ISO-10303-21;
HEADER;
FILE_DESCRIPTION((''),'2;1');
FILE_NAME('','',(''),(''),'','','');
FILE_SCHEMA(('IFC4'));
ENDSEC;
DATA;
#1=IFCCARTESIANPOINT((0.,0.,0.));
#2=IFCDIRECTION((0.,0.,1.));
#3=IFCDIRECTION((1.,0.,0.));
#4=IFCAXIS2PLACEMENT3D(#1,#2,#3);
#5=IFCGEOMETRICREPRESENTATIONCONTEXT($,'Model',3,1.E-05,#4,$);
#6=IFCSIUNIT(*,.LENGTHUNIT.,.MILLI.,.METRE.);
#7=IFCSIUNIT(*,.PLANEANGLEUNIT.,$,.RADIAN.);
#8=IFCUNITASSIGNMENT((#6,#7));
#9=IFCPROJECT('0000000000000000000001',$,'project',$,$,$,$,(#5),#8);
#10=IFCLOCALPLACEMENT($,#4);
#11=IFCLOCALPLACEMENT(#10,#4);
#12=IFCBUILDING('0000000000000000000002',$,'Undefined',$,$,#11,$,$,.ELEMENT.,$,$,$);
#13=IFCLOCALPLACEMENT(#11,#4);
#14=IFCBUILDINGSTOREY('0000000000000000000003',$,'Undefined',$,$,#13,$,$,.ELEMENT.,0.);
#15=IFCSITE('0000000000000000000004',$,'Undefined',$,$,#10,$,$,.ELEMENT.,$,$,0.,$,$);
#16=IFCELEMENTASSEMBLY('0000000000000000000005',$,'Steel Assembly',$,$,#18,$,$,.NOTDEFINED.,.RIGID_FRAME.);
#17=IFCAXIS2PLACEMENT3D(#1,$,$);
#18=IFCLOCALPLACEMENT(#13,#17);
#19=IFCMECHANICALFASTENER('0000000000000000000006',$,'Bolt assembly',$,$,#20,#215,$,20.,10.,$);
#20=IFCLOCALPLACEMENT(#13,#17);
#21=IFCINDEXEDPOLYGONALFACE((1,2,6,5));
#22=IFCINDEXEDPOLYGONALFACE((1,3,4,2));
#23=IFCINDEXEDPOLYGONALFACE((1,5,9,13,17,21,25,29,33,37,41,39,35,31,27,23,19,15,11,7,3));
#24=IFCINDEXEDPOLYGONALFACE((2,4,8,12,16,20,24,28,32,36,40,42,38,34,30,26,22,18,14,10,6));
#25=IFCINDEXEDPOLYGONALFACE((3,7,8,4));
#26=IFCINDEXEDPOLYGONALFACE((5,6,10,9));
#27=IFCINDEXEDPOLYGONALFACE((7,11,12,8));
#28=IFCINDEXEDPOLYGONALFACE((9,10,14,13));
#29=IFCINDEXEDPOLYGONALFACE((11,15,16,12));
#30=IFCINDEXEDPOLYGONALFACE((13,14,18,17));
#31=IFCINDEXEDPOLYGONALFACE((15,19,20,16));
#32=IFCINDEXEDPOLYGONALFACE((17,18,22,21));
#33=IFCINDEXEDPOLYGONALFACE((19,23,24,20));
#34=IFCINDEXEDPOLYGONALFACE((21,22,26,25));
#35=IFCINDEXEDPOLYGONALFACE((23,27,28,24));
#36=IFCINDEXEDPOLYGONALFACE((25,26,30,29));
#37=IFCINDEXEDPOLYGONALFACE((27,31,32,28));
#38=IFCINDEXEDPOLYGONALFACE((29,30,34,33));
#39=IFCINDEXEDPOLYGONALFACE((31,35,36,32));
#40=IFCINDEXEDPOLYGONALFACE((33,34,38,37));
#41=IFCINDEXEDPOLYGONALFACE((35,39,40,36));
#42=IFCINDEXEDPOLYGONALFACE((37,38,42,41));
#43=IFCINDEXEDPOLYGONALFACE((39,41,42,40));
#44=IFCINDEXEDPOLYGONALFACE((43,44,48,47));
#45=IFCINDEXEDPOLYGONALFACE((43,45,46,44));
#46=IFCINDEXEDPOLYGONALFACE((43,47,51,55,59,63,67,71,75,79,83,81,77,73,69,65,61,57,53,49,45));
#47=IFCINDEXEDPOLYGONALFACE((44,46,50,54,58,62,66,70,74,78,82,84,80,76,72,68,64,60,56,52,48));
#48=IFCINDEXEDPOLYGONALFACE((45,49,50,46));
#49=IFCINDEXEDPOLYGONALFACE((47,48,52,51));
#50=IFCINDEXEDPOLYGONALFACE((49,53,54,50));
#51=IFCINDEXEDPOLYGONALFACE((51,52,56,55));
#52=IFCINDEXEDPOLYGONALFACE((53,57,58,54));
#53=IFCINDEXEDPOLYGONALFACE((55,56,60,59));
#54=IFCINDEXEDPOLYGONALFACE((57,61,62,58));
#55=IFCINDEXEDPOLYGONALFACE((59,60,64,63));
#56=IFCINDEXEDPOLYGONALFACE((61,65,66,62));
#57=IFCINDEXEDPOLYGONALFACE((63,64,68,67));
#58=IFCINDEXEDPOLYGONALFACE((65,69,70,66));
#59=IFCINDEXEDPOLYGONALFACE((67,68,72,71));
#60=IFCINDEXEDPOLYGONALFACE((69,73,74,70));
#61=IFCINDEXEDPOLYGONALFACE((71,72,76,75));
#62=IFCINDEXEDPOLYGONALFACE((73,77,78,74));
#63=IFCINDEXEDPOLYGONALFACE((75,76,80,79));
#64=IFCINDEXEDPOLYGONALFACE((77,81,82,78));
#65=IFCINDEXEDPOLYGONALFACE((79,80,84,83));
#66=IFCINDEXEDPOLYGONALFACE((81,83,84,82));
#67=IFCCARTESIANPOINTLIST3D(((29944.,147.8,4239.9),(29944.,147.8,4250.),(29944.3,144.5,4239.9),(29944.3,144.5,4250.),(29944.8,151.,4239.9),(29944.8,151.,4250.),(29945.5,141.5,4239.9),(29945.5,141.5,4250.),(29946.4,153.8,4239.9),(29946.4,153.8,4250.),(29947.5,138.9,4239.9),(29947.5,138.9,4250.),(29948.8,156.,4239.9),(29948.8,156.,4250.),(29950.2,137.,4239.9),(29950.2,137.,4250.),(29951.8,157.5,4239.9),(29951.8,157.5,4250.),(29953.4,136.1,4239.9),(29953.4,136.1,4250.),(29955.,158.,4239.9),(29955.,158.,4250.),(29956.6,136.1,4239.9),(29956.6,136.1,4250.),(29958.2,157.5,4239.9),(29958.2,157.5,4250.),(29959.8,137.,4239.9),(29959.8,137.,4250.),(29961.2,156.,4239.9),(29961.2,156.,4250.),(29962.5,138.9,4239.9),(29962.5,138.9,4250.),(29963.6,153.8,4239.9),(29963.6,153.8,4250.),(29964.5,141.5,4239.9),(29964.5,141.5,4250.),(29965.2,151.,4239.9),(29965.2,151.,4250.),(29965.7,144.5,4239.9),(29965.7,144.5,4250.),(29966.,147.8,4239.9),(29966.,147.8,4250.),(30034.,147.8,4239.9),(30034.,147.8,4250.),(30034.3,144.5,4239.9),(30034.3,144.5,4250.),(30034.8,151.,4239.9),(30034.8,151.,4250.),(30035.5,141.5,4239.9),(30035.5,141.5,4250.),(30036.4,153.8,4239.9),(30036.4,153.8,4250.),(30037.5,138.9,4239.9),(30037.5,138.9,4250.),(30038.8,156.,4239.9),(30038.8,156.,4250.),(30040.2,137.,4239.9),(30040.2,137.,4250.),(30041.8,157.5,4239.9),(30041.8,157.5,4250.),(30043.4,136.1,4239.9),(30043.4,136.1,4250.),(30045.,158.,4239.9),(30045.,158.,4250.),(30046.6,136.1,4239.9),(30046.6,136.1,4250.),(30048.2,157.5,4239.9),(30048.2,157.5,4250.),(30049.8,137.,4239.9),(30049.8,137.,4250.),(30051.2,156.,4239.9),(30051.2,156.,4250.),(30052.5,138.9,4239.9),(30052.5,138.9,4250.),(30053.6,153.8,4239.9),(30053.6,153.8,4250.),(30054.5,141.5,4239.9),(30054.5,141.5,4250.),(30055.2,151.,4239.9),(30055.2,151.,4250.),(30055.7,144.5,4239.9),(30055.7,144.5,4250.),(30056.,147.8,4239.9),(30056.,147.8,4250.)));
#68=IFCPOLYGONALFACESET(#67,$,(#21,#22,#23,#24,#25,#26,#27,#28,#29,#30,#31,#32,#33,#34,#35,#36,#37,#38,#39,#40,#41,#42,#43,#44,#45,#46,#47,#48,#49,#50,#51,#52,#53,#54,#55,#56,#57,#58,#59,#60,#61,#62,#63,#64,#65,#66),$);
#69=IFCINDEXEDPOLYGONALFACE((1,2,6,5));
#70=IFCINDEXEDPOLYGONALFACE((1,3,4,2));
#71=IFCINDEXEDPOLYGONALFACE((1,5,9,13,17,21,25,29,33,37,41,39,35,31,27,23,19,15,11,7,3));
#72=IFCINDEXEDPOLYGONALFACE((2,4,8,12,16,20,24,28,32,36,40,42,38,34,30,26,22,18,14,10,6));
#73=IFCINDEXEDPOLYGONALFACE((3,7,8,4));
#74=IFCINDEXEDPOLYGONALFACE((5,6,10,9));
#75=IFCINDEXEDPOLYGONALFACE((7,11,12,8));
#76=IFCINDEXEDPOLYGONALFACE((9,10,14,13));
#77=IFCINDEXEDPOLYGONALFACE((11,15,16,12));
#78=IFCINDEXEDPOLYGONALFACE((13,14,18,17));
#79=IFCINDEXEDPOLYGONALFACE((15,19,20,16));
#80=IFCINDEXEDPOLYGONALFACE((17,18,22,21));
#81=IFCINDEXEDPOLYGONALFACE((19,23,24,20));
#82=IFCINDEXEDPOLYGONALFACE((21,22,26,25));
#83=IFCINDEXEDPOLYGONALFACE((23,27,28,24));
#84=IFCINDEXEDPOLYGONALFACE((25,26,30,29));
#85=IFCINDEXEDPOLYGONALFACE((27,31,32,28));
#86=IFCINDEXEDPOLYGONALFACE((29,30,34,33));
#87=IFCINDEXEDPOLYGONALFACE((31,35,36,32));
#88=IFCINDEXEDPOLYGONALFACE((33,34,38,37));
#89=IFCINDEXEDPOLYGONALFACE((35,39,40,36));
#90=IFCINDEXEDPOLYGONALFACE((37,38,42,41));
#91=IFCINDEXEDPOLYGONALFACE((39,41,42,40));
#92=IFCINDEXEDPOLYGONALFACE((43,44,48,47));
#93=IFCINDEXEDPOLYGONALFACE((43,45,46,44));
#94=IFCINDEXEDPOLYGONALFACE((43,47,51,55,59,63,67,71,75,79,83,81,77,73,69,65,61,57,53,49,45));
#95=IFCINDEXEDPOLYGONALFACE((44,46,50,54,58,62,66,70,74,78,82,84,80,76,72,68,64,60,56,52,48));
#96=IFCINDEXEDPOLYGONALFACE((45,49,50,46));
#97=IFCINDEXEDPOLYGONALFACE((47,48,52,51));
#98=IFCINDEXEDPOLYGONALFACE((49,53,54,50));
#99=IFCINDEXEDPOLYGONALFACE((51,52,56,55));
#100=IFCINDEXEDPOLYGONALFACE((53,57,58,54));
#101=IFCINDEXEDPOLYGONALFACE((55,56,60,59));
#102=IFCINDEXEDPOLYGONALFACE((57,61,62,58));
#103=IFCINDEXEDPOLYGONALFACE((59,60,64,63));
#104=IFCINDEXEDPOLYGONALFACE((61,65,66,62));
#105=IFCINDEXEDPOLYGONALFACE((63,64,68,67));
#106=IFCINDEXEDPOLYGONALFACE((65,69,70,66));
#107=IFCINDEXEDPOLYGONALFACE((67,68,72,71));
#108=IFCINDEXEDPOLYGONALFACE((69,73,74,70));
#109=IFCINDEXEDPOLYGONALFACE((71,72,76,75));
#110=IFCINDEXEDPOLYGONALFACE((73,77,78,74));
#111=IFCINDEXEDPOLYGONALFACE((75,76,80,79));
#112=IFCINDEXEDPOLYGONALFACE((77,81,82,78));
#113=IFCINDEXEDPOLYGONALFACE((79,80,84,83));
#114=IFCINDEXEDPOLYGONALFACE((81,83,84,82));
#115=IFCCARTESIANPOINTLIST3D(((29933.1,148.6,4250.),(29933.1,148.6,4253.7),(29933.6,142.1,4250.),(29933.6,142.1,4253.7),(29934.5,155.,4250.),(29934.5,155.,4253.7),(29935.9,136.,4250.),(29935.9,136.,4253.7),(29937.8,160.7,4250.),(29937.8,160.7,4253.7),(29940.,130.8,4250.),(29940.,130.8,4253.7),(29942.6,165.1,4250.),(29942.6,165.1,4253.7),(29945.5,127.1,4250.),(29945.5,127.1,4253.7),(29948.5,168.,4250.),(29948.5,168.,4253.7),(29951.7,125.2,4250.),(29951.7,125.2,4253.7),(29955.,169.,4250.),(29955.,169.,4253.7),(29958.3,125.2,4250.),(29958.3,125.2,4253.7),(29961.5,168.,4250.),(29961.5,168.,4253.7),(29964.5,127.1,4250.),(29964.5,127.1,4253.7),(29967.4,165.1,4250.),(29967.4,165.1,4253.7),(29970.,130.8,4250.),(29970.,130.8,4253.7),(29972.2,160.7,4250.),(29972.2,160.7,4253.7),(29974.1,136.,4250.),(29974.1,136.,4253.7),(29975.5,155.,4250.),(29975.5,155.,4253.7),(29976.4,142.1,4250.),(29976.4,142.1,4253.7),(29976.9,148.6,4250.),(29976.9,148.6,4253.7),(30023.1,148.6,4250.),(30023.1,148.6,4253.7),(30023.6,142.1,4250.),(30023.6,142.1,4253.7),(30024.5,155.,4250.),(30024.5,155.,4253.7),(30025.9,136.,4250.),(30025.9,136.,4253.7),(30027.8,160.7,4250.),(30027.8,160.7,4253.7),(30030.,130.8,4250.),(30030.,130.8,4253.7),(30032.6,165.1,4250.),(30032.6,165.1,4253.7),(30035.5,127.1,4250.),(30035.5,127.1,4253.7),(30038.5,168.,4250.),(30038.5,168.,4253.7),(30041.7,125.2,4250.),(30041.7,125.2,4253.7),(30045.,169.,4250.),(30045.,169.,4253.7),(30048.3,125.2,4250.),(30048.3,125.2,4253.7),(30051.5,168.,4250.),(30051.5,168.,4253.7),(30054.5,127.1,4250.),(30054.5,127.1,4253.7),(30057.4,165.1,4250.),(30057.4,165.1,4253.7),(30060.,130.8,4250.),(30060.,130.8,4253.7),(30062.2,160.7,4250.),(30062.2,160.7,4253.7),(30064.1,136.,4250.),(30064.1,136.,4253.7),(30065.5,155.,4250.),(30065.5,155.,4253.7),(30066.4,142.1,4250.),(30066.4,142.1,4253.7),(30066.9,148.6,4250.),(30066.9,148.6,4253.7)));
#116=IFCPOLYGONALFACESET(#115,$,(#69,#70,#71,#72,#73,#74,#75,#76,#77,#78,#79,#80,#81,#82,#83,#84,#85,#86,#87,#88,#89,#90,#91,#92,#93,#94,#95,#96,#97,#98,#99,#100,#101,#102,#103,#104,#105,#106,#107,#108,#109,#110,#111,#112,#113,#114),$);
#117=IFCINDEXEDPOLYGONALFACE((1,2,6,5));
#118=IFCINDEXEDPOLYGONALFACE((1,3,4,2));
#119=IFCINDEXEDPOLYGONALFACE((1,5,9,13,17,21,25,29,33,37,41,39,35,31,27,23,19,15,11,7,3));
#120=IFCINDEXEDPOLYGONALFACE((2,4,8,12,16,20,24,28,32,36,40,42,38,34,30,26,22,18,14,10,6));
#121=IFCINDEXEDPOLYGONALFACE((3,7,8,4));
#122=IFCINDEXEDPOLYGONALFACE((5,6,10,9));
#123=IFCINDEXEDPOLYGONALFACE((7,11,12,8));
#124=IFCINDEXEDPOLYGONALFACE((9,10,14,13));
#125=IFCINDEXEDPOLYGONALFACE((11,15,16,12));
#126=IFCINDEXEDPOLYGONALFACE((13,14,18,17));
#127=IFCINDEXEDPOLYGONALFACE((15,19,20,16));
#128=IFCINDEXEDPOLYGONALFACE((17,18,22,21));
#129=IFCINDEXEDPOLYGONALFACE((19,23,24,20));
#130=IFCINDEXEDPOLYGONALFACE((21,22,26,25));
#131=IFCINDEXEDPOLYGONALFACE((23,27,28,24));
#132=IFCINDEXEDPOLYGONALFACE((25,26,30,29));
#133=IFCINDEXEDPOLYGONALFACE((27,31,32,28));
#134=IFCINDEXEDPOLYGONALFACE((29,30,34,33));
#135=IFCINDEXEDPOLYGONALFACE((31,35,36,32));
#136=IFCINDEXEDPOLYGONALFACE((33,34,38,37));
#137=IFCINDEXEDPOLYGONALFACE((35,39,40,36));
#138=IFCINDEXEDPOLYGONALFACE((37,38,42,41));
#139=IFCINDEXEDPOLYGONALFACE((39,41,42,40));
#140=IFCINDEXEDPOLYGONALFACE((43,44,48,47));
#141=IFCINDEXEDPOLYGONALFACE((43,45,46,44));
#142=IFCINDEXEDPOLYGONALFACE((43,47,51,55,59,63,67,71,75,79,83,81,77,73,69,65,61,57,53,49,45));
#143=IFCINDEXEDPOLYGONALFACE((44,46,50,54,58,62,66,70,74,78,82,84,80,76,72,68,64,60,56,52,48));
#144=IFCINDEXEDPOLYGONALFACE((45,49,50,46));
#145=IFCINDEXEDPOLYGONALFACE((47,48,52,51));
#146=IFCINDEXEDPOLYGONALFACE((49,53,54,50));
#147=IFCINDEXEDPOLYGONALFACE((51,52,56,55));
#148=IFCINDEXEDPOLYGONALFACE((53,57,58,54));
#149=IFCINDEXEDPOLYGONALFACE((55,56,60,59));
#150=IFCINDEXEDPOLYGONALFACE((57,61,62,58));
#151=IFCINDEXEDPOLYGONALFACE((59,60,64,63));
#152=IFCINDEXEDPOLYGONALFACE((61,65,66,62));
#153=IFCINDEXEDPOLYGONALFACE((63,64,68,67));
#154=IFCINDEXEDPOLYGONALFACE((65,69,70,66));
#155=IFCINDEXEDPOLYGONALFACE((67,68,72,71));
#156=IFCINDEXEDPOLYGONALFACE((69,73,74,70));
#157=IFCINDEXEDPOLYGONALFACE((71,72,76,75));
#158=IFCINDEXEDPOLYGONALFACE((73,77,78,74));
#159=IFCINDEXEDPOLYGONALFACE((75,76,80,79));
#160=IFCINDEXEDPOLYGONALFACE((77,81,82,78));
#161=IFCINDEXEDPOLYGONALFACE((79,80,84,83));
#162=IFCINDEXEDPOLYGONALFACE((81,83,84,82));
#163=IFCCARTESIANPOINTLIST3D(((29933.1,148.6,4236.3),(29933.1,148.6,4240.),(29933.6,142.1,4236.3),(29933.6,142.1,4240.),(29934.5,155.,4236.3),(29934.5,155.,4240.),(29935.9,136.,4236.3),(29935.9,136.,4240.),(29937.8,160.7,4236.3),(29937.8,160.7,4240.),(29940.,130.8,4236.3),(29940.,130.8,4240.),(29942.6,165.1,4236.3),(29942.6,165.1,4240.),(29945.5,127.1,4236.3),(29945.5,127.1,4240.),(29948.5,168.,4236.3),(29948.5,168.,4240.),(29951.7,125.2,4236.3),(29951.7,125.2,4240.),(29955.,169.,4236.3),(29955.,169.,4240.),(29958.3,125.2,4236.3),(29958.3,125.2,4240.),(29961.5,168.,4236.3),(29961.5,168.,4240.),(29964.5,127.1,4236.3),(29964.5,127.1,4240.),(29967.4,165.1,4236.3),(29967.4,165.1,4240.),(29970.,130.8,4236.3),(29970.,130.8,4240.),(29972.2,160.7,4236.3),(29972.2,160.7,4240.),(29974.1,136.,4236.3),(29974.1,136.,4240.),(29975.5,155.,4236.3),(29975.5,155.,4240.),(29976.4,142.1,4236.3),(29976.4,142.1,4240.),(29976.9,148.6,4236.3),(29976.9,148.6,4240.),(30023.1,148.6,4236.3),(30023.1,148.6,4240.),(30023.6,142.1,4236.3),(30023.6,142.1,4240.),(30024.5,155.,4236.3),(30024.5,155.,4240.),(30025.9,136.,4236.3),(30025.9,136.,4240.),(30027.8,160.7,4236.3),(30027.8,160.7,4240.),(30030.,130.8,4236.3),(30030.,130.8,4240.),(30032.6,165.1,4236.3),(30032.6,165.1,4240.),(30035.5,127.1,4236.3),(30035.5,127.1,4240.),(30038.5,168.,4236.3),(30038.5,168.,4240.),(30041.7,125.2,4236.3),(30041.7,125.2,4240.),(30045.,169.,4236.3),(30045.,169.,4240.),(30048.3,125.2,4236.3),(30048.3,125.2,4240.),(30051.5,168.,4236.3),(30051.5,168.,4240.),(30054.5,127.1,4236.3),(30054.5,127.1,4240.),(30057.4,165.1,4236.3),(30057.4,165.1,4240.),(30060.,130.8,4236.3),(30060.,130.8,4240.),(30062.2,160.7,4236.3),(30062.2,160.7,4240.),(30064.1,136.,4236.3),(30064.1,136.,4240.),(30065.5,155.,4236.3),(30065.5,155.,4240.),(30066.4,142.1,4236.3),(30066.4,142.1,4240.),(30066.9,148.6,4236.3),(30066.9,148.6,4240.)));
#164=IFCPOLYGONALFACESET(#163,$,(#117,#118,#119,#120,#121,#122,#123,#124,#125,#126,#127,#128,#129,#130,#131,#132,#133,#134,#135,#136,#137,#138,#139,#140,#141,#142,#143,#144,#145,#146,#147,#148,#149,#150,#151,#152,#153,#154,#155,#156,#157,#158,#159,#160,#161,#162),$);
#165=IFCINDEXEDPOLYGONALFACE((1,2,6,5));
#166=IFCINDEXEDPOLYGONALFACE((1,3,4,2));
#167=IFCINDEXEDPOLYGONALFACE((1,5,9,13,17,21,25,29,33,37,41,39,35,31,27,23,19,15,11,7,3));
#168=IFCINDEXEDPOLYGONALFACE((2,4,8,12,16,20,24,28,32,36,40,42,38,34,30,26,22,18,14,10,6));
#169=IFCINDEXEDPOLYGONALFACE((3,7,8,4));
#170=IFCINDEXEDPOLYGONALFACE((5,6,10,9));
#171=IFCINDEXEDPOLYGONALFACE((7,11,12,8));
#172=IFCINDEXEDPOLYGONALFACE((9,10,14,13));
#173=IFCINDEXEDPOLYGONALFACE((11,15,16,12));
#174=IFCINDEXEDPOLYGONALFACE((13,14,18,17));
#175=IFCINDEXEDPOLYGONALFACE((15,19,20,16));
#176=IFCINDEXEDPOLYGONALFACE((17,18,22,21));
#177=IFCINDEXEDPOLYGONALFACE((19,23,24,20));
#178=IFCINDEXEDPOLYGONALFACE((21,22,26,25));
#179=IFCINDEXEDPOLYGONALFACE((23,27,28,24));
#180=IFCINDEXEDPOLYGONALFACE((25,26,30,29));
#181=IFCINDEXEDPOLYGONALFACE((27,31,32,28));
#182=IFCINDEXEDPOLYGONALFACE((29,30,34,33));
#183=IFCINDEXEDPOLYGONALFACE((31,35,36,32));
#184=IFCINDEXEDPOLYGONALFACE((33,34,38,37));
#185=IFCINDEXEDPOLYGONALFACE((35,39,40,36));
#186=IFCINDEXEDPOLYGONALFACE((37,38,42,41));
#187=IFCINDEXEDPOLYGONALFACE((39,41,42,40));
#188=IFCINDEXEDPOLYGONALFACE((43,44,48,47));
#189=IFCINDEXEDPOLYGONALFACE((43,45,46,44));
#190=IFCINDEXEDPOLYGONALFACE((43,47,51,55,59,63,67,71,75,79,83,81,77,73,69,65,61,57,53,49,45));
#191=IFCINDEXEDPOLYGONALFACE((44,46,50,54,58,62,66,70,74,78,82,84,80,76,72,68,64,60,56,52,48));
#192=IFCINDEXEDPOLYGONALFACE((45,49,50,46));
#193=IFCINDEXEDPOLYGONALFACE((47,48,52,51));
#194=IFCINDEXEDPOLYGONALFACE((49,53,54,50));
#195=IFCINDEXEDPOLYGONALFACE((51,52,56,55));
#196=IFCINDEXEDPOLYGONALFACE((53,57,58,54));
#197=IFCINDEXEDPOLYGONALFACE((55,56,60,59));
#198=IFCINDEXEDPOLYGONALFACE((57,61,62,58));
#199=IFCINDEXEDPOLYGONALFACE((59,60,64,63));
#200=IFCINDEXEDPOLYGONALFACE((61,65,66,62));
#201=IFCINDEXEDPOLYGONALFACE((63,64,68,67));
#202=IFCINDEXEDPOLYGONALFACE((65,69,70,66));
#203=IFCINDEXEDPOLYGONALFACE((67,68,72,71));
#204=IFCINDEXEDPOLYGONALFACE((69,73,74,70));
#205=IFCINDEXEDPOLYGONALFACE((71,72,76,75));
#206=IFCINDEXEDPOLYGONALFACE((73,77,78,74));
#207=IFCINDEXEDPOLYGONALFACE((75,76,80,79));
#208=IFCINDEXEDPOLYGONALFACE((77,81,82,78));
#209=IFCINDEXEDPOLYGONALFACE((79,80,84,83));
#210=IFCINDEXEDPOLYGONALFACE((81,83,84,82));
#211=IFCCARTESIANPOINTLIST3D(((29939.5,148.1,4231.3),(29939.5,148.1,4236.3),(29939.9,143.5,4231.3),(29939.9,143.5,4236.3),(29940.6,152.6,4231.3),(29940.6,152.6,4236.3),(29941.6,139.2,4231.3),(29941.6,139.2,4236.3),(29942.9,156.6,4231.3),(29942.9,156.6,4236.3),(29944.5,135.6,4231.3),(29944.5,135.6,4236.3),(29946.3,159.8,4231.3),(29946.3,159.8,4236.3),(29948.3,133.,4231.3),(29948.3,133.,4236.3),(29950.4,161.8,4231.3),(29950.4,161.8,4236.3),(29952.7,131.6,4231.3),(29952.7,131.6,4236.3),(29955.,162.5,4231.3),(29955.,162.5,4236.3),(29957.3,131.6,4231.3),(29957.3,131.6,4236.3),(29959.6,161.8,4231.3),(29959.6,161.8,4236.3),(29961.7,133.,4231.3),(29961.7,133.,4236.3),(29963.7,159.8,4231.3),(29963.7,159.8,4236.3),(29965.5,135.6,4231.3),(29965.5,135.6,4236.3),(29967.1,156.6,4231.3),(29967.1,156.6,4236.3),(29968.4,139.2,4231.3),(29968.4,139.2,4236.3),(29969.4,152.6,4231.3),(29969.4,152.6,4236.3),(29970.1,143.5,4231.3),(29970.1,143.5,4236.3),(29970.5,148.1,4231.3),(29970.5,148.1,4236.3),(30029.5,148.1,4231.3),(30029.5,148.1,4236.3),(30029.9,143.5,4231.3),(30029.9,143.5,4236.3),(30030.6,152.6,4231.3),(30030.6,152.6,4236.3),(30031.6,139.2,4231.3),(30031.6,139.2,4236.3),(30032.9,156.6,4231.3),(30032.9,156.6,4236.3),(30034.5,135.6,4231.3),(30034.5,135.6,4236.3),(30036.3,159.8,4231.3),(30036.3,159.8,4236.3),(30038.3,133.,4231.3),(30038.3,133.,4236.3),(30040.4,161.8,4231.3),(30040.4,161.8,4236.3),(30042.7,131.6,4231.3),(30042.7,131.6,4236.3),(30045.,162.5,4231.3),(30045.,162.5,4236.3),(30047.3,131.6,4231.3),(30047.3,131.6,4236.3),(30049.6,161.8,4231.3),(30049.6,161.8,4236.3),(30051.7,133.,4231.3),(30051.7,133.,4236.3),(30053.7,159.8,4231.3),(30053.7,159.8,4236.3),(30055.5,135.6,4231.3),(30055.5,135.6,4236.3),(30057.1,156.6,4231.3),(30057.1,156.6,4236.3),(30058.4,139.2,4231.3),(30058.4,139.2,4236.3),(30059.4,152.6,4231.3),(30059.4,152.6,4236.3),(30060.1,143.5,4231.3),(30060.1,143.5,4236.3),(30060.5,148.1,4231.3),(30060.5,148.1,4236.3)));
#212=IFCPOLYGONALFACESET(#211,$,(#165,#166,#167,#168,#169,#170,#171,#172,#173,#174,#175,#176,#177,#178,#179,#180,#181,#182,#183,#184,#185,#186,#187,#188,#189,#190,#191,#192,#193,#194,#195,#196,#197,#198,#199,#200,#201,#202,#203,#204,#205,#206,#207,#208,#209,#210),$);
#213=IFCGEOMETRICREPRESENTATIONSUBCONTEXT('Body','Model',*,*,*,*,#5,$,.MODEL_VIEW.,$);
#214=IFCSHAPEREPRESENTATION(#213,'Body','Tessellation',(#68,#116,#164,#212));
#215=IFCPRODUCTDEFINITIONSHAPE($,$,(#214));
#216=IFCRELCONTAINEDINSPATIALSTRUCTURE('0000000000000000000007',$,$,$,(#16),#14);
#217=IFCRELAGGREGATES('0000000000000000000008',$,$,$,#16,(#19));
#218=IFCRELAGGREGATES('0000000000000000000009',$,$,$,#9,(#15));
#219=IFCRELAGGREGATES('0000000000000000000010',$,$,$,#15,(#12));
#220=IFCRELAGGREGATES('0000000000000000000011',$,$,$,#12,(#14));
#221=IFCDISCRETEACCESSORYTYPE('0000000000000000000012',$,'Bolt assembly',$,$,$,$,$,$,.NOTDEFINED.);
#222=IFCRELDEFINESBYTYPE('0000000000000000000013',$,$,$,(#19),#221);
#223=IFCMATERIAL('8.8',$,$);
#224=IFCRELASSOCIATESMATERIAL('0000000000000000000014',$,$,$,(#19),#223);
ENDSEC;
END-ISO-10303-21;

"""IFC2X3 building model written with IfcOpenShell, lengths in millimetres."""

from ifc_helpers import new_model, si_unit, frame, origin_with_axes, origin_2d_with_axis, place, context, subcontext, project, spatial, circle, extrude, source, transform, mapped, material, type_object, element, aggregate, save


model = new_model("IFC2X3")

# Units and contexts
model_context = context("Model", 3, precision=1e-05, world=origin_with_axes())
body_context = subcontext(model_context, "Body", "Model", "MODEL_VIEW")
ifc_project = project(units=[si_unit("LENGTHUNIT", "METRE", prefix="MILLI"), si_unit("PLANEANGLEUNIT", "RADIAN")], contexts=[model_context])

# Site, building, storey
site_placement = place(None, origin_with_axes())
site = spatial("IfcSite", under=ifc_project, at=site_placement, Name="Undefined", CompositionType="ELEMENT", RefElevation=0.0)
building_placement = place(site_placement, origin_with_axes())
building = spatial("IfcBuilding", under=site, at=building_placement, Name="Undefined", CompositionType="ELEMENT")
storey_placement = place(building_placement, origin_with_axes())
storey = spatial("IfcBuildingStorey", under=building, at=storey_placement, Name="Undefined", CompositionType="ELEMENT", Elevation=0.0)

# Element assembly
assembly_1_placement = place(storey_placement, origin_with_axes())
assembly_1 = element("IfcElementAssembly", 1, at=assembly_1_placement, inside=storey, Name="Steel Assembly", AssemblyPlace="NOTDEFINED", PredefinedType="RIGID_FRAME")

# Shared definitions
ifc_material_1 = material(Name="8.8")
discrete_accessory_type_1 = type_object("IfcDiscreteAccessoryType", Name="Bolt assembly")

# Mechanical fastener
shared_shape_1 = source(origin_with_axes(), body_context, "Body", "SweptSolid", [
    extrude(circle(Radius=11.0, at=origin_2d_with_axis()), frame((0.0, -10.0, 0.0), z_axis=(0.0, 1.0, 0.0), x_axis=(1.0, 0.0, 0.0)), (0.0, 0.0, 1.0), 10.1),
    extrude(circle(Radius=22.0, at=origin_2d_with_axis()), frame((0.0, -13.7, 0.0), z_axis=(0.0, 1.0, 0.0), x_axis=(1.0, 0.0, 0.0)), (0.0, 0.0, 1.0), 3.7),
    extrude(circle(Radius=22.0, at=origin_2d_with_axis()), frame((0.0, 0.0, 0.0), z_axis=(0.0, 1.0, 0.0), x_axis=(1.0, 0.0, 0.0)), (0.0, 0.0, 1.0), 3.7),
    extrude(circle(Radius=15.5, at=origin_2d_with_axis()), frame((0.0, 3.7, 0.0), z_axis=(0.0, 1.0, 0.0), x_axis=(1.0, 0.0, 0.0)), (0.0, 0.0, 1.0), 5.0),
])
mechanical_fastener_1_placement = place(assembly_1_placement, frame((30000.0, 147.0, 4240.0), z_axis=(-1.0, 0.0, 0.0), x_axis=(0.0, 1.0, 0.0)))
mechanical_fastener_1 = element("IfcMechanicalFastener", 2, at=mechanical_fastener_1_placement, type_object=discrete_accessory_type_1, material=ifc_material_1, Name="Bolt assembly", NominalDiameter=20.0, NominalLength=10.0, context=body_context, shape_type="MappedRepresentation", body=[
    mapped(shared_shape_1, transform((0.0, 0.0, -45.0))),
    mapped(shared_shape_1, transform((0.0, 0.0, 45.0))),
])
aggregate(assembly_1, [mechanical_fastener_1])

save(model, "model.ifc")
